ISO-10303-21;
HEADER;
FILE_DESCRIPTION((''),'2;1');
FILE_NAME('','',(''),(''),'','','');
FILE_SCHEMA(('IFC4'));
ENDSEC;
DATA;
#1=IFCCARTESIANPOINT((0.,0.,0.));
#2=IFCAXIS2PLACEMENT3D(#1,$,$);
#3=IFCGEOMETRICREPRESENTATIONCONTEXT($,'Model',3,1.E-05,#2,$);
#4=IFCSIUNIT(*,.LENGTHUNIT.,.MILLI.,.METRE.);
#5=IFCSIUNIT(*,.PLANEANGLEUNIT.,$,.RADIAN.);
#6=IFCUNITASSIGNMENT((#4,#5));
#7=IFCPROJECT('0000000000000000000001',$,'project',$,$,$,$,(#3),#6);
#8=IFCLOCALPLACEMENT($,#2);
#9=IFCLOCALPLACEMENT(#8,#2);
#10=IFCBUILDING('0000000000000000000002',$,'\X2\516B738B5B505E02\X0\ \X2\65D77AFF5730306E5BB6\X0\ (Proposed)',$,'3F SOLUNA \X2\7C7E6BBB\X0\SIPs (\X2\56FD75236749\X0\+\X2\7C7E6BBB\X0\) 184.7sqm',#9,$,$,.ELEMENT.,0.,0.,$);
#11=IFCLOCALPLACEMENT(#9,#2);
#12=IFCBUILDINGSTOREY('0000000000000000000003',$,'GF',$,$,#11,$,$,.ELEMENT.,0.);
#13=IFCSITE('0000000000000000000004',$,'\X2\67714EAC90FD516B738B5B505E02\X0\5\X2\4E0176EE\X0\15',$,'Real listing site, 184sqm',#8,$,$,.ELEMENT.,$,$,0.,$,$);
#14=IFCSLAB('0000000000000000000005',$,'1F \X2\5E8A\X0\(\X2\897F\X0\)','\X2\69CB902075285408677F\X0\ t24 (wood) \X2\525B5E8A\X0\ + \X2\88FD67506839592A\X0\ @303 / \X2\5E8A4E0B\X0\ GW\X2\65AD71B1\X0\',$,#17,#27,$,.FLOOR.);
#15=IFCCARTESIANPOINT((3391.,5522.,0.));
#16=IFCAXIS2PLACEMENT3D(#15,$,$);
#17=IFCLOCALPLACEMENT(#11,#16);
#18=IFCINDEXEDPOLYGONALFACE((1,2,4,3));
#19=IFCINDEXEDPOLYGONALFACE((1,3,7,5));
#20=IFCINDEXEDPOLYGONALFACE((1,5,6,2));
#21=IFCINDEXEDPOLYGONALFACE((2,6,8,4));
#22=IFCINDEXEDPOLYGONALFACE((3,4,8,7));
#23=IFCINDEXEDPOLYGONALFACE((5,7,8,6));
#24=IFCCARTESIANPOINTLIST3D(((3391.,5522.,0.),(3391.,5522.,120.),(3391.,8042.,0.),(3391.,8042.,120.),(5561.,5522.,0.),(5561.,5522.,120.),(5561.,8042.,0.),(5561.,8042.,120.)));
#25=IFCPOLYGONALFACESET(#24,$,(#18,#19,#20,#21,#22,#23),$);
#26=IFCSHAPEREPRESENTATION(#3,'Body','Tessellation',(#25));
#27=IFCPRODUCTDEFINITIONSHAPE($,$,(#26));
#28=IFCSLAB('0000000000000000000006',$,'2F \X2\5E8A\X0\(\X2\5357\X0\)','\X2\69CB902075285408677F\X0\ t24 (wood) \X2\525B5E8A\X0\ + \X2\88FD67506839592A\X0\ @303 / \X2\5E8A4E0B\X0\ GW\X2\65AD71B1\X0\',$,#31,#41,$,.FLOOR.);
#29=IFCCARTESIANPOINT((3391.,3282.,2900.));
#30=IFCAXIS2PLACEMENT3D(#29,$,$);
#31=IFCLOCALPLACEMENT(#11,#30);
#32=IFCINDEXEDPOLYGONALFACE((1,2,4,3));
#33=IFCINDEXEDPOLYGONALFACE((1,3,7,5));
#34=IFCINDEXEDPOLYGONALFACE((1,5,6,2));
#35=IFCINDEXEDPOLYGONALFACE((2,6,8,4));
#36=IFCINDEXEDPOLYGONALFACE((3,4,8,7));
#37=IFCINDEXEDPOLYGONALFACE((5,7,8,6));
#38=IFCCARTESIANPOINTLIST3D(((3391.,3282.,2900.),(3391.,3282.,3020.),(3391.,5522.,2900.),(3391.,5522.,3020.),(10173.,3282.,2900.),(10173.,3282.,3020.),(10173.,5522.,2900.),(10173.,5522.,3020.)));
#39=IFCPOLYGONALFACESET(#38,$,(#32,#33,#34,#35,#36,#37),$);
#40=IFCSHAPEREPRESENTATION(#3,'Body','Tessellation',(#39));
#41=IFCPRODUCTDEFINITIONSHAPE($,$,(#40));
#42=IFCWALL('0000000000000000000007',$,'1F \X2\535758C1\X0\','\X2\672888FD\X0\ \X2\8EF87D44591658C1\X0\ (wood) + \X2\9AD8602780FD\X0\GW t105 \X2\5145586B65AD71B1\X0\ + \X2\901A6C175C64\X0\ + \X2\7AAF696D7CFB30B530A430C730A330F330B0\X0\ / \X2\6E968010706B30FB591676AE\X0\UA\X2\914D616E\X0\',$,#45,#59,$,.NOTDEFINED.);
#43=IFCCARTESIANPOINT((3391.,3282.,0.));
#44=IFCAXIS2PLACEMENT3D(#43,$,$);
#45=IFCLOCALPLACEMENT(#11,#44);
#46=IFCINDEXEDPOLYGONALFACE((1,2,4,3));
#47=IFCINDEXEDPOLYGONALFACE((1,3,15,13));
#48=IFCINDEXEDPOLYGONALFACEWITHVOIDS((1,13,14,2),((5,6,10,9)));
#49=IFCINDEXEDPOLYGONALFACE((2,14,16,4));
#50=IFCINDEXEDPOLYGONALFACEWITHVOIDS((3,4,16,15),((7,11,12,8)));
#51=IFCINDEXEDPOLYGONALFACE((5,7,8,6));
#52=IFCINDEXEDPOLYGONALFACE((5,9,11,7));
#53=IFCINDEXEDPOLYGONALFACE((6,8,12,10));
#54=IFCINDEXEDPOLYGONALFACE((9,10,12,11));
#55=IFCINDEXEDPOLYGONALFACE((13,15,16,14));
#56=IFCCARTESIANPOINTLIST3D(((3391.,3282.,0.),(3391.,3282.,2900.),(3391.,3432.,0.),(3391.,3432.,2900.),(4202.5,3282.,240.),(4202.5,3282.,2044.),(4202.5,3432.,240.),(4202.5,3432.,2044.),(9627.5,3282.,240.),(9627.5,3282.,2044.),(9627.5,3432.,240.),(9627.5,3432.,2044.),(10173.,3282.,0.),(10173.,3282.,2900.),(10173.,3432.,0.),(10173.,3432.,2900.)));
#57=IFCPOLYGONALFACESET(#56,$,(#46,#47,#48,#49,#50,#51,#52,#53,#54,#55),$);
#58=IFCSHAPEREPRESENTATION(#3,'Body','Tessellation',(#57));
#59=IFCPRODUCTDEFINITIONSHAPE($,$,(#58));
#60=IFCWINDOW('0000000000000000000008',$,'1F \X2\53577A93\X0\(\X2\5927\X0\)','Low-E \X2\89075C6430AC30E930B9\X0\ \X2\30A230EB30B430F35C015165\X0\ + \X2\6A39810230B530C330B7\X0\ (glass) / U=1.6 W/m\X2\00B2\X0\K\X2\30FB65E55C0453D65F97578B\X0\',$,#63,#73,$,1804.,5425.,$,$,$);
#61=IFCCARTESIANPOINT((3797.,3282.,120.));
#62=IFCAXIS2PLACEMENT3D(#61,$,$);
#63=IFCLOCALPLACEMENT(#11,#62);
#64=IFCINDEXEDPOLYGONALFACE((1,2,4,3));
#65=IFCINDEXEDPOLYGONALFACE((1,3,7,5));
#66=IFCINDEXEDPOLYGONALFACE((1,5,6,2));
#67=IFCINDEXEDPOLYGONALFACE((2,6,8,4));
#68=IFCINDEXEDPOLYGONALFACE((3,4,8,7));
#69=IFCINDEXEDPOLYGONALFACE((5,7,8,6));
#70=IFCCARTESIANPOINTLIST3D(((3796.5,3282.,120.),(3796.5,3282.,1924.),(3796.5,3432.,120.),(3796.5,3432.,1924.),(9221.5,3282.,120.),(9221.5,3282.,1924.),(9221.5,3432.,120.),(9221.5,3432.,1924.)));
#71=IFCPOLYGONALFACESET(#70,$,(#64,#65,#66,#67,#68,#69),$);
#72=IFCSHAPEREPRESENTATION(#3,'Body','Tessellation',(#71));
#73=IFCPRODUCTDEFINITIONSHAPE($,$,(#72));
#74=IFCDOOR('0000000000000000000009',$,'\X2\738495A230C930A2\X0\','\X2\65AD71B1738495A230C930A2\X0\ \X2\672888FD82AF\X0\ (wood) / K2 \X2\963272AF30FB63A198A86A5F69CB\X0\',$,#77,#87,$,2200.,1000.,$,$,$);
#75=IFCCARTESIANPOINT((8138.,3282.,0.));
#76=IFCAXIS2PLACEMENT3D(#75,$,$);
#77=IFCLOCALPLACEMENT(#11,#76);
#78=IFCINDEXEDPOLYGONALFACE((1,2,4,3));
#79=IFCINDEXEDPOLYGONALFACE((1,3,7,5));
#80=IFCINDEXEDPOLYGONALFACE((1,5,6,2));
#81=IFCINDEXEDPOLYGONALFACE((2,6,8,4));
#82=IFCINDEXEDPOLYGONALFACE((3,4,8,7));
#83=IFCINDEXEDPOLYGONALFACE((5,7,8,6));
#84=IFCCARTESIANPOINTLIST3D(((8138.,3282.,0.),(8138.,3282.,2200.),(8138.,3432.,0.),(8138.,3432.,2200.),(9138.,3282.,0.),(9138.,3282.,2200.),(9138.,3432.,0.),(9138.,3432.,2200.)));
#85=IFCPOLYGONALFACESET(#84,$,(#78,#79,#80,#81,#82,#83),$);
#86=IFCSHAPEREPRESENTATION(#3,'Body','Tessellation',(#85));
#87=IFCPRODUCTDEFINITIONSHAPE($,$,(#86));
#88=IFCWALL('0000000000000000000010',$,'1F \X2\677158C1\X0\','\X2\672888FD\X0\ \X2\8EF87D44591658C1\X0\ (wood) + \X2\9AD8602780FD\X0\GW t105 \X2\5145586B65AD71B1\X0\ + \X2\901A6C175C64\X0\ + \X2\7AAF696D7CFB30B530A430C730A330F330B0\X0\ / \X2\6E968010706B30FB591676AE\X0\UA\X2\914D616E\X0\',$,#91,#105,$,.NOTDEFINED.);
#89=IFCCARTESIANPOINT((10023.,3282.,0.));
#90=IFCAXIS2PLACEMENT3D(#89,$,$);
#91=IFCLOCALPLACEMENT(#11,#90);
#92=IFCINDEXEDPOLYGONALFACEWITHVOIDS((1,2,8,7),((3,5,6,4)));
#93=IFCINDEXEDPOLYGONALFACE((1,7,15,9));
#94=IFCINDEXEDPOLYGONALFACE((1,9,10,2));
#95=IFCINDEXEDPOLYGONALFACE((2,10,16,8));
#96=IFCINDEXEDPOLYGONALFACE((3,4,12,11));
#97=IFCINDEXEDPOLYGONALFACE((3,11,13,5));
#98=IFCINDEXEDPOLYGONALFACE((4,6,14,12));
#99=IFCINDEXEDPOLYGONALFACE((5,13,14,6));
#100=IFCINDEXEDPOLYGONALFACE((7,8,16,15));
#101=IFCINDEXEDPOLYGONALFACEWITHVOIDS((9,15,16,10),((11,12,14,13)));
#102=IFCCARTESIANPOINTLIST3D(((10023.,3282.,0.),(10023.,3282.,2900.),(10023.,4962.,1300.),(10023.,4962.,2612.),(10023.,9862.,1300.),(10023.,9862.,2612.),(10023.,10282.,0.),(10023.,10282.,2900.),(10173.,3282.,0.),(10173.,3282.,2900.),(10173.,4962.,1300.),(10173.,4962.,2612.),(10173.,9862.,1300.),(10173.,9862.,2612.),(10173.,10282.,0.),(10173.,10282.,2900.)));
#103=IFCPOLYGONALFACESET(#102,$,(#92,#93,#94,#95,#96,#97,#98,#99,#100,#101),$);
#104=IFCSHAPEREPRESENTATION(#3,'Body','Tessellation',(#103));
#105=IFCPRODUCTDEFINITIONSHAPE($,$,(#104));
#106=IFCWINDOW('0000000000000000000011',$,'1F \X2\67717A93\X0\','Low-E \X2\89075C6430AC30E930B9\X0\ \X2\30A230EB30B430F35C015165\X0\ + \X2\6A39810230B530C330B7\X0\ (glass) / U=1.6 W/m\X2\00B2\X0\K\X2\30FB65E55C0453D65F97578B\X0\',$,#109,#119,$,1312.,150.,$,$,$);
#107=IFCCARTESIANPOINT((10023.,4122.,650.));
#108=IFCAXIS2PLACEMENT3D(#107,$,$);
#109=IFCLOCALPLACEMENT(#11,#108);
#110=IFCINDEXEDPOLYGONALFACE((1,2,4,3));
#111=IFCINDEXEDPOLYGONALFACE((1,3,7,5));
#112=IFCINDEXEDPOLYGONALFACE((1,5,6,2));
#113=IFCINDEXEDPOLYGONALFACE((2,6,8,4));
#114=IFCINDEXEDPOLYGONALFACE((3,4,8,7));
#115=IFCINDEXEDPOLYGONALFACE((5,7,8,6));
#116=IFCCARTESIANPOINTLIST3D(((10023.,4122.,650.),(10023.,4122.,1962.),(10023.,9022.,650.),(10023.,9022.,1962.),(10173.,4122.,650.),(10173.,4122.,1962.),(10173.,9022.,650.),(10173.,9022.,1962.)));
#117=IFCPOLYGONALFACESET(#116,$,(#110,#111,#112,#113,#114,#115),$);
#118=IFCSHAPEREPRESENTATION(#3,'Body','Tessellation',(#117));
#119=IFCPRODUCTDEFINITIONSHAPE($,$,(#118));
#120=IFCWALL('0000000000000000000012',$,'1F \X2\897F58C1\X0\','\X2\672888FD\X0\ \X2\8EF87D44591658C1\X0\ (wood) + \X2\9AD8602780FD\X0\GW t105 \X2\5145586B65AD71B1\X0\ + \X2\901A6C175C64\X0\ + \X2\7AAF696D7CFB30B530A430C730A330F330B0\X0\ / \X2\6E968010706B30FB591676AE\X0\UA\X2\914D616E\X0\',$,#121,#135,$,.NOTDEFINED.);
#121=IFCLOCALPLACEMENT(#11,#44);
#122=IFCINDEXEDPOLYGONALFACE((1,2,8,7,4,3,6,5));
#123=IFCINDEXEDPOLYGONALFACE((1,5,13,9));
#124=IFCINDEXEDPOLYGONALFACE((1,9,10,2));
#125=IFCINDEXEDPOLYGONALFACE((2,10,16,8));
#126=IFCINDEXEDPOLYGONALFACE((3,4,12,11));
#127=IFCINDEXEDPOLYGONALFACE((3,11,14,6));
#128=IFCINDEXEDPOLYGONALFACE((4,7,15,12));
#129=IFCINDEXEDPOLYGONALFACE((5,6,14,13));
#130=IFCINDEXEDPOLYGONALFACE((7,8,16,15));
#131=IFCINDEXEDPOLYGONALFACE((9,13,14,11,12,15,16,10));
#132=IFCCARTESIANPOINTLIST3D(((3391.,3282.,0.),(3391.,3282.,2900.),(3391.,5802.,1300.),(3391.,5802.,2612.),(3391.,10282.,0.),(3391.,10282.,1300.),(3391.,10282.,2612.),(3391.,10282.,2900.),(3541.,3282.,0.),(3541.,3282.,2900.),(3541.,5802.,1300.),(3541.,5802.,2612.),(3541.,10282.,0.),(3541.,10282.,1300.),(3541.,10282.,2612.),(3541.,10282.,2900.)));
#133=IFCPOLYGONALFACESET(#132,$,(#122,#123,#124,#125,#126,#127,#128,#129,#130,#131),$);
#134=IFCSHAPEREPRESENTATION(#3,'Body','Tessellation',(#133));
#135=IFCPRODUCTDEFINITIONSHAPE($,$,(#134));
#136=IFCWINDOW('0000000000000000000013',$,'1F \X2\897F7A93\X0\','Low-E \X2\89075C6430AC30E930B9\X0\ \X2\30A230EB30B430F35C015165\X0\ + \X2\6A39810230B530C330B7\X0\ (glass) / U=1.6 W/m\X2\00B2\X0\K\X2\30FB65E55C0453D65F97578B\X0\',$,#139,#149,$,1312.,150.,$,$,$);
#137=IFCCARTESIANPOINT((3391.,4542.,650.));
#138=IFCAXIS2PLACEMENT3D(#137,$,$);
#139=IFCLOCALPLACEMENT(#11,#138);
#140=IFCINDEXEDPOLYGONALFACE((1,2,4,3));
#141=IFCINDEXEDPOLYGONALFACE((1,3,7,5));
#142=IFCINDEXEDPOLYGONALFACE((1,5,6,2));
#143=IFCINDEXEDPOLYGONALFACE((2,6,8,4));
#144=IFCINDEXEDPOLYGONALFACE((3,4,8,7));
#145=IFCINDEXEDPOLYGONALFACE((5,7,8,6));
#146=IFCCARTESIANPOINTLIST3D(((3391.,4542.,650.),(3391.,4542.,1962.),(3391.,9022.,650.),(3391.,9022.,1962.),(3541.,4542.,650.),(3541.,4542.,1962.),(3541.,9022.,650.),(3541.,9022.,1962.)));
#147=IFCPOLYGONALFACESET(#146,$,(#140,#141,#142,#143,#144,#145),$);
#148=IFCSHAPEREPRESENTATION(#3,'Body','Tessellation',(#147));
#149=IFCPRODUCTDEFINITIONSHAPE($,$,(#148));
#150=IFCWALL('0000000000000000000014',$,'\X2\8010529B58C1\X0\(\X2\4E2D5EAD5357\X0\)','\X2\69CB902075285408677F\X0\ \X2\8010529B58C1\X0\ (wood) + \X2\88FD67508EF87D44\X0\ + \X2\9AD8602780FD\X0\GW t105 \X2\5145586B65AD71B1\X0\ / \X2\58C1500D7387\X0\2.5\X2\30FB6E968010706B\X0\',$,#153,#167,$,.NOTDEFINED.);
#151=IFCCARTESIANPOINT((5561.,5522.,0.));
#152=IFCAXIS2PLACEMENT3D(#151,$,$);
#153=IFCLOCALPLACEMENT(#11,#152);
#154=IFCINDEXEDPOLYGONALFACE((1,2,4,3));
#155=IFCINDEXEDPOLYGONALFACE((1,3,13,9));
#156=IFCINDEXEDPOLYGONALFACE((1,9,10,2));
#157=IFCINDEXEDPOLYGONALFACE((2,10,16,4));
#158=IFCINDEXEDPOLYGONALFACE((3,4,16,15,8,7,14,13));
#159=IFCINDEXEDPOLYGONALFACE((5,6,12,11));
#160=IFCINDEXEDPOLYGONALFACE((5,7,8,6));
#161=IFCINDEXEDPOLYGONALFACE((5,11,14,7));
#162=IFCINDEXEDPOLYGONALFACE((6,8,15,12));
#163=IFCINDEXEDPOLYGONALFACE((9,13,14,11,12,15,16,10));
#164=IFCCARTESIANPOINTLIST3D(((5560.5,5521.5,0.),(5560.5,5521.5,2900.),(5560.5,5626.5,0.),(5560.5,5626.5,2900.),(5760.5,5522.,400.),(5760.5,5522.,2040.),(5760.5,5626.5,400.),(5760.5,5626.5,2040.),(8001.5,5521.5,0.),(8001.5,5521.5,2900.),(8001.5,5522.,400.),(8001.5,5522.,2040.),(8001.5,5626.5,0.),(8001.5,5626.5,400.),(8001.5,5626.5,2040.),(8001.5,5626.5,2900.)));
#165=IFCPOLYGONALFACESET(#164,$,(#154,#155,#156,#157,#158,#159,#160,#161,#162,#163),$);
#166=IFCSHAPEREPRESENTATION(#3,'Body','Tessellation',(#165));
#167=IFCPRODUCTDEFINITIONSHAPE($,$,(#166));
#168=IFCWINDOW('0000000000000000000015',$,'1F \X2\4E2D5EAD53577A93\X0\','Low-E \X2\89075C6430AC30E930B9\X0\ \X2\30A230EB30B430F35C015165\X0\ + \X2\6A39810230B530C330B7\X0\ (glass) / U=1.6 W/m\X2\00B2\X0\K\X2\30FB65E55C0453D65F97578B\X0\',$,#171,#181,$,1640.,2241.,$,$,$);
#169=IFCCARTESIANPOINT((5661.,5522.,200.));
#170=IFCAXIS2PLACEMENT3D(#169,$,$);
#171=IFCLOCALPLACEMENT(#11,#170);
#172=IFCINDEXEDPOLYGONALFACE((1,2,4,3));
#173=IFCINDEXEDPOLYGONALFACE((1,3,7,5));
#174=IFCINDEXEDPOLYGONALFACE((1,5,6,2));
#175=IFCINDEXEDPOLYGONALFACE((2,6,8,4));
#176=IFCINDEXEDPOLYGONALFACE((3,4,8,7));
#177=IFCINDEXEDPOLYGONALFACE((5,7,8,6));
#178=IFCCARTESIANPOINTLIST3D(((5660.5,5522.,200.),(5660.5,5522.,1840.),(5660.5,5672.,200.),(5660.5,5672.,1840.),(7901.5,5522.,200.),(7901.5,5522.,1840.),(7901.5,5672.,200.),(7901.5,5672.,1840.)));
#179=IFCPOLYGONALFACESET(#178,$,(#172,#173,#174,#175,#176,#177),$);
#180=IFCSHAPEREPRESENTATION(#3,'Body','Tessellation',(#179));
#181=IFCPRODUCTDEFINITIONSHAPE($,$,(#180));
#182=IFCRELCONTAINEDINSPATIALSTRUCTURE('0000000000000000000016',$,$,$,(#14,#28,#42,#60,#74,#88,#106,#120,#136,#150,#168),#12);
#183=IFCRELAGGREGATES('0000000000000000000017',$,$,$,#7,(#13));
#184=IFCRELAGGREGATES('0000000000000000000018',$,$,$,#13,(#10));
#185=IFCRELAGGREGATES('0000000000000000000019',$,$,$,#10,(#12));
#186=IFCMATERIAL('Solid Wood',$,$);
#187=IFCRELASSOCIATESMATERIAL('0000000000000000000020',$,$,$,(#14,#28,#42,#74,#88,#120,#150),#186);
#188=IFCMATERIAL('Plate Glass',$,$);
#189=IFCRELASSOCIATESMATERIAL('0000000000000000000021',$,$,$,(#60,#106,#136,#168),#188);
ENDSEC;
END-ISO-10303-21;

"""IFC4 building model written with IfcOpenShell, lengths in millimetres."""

from ifc_helpers import new_model, si_unit, frame, frame_2d, origin, place, context, project, spatial, rectangle, extrude, material, element, fill, save


model = new_model("IFC4")

# Units and contexts
model_context = context("Model", 3, precision=1e-05, world=origin())
ifc_project = project(units=[si_unit("LENGTHUNIT", "METRE", prefix="MILLI"), si_unit("PLANEANGLEUNIT", "RADIAN")], contexts=[model_context])

# Site, building, storey
site_placement = place(None, origin())
site = spatial("IfcSite", under=ifc_project, at=site_placement, Name="東京都八王子市5丁目15", ObjectType="Real listing site, 184sqm", CompositionType="ELEMENT", RefElevation=0.0)
building_placement = place(site_placement, origin())
building = spatial("IfcBuilding", under=site, at=building_placement, Name="八王子市 旗竿地の家 (Proposed)", ObjectType="3F SOLUNA 籾殻SIPs (国産杉+籾殻) 184.7sqm", CompositionType="ELEMENT", ElevationOfRefHeight=0.0, ElevationOfTerrain=0.0)
storey_placement = place(building_placement, origin())
storey = spatial("IfcBuildingStorey", under=building, at=storey_placement, Name="GF", CompositionType="ELEMENT", Elevation=0.0)

# Slabs
ifc_material_1 = material(Name="Solid Wood")
slab_1_placement = place(storey_placement, frame((3391.0, 5522.0, 0.0)))
element("IfcSlab", 1, at=slab_1_placement, inside=storey, material=ifc_material_1, Name="1F 床(西)", Description="構造用合板 t24 (wood) 剛床 + 製材根太 @303 / 床下 GW断熱", PredefinedType="FLOOR", context=model_context, shape_type="SweptSolid", body=[
    extrude(rectangle(XDim=2170.0, YDim=2520.0, at=frame_2d((1085.0, 1260.0))), frame((3391.0, 5522.0, 0.0)), (0.0, 0.0, 1.0), 120.0),
])
slab_2_placement = place(storey_placement, frame((3391.0, 3282.0, 2900.0)))
element("IfcSlab", 2, at=slab_2_placement, inside=storey, material=ifc_material_1, Name="2F 床(南)", Description="構造用合板 t24 (wood) 剛床 + 製材根太 @303 / 床下 GW断熱", PredefinedType="FLOOR", context=model_context, shape_type="SweptSolid", body=[
    extrude(rectangle(XDim=6782.0, YDim=2240.0, at=frame_2d((3391.0, 1120.0))), frame((3391.0, 3282.0, 2900.0)), (0.0, 0.0, 1.0), 120.0),
])

# Wall, openings, window, door
wall_1_placement = place(storey_placement, frame((3391.0, 3282.0, 0.0)))
wall_1 = element("IfcWall", 3, at=wall_1_placement, inside=storey, material=ifc_material_1, Name="1F 南壁", Description="木製 軸組外壁 (wood) + 高性能GW t105 充填断熱 + 通気層 + 窯業系サイディング / 準耐火・外皮UA配慮", PredefinedType="NOTDEFINED", context=model_context, shape_type="SweptSolid", body=[
    extrude(rectangle(XDim=6782.0, YDim=150.0, at=frame_2d((3391.0, 75.0))), frame((3391.0, 3282.0, 0.0)), (0.0, 0.0, 1.0), 2900.0),
])
opening_1_placement = place(storey_placement, frame((3797.0, 3282.0, 120.0)))
opening_1 = element("IfcOpeningElement", 4, at=opening_1_placement, cuts=wall_1, PredefinedType="NOTDEFINED", context=model_context, shape_type="SweptSolid", body=[
    extrude(rectangle(XDim=5425.0, YDim=150.0, at=frame_2d((2712.0, 75.0))), frame((3797.0, 3282.0, 120.0)), (0.0, 0.0, 1.0), 1804.0),
])
opening_2_placement = place(storey_placement, frame((8138.0, 3282.0, 0.0)))
opening_2 = element("IfcOpeningElement", 5, at=opening_2_placement, cuts=wall_1, PredefinedType="NOTDEFINED", context=model_context, shape_type="SweptSolid", body=[
    extrude(rectangle(XDim=1000.0, YDim=150.0, at=frame_2d((500.0, 75.0))), frame((8138.0, 3282.0, 0.0)), (0.0, 0.0, 1.0), 2200.0),
])
ifc_material_2 = material(Name="Plate Glass")
window_1_placement = place(storey_placement, frame((3797.0, 3282.0, 120.0)))
window_1 = element("IfcWindow", 6, at=window_1_placement, inside=storey, material=ifc_material_2, Name="1F 南窓(大)", Description="Low-E 複層ガラス アルゴン封入 + 樹脂サッシ (glass) / U=1.6 W/m²K・日射取得型", OverallHeight=1804.0, OverallWidth=5425.0, context=model_context, shape_type="SweptSolid", body=[
    extrude(rectangle(XDim=5425.0, YDim=150.0, at=frame_2d((2712.0, 75.0))), frame((3797.0, 3282.0, 120.0)), (0.0, 0.0, 1.0), 1804.0),
])
fill(opening_1, window_1)
door_placement = place(storey_placement, frame((8138.0, 3282.0, 0.0)))
door = element("IfcDoor", 7, at=door_placement, inside=storey, material=ifc_material_1, Name="玄関ドア", Description="断熱玄関ドア 木製芯 (wood) / K2 防犯・採風機構", OverallHeight=2200.0, OverallWidth=1000.0, context=model_context, shape_type="SweptSolid", body=[
    extrude(rectangle(XDim=1000.0, YDim=150.0, at=frame_2d((500.0, 75.0))), frame((8138.0, 3282.0, 0.0)), (0.0, 0.0, 1.0), 2200.0),
])
fill(opening_2, door)

# Walls, openings, windows
wall_2_placement = place(storey_placement, frame((10023.0, 3282.0, 0.0)))
wall_2 = element("IfcWall", 8, at=wall_2_placement, inside=storey, material=ifc_material_1, Name="1F 東壁", Description="木製 軸組外壁 (wood) + 高性能GW t105 充填断熱 + 通気層 + 窯業系サイディング / 準耐火・外皮UA配慮", PredefinedType="NOTDEFINED", context=model_context, shape_type="SweptSolid", body=[
    extrude(rectangle(XDim=150.0, YDim=7000.0, at=frame_2d((75.0, 3500.0))), frame((10023.0, 3282.0, 0.0)), (0.0, 0.0, 1.0), 2900.0),
])
opening_3_placement = place(storey_placement, frame((10023.0, 4122.0, 650.0)))
opening_3 = element("IfcOpeningElement", 9, at=opening_3_placement, cuts=wall_2, PredefinedType="NOTDEFINED", context=model_context, shape_type="SweptSolid", body=[
    extrude(rectangle(XDim=150.0, YDim=4900.0, at=frame_2d((75.0, 2450.0))), frame((10023.0, 4122.0, 650.0)), (0.0, 0.0, 1.0), 1312.0),
])
window_2_placement = place(storey_placement, frame((10023.0, 4122.0, 650.0)))
window_2 = element("IfcWindow", 10, at=window_2_placement, inside=storey, material=ifc_material_2, Name="1F 東窓", Description="Low-E 複層ガラス アルゴン封入 + 樹脂サッシ (glass) / U=1.6 W/m²K・日射取得型", OverallHeight=1312.0, OverallWidth=150.0, context=model_context, shape_type="SweptSolid", body=[
    extrude(rectangle(XDim=150.0, YDim=4900.0, at=frame_2d((75.0, 2450.0))), frame((10023.0, 4122.0, 650.0)), (0.0, 0.0, 1.0), 1312.0),
])
fill(opening_3, window_2)
wall_3_placement = place(storey_placement, frame((3391.0, 3282.0, 0.0)))
wall_3 = element("IfcWall", 11, at=wall_3_placement, inside=storey, material=ifc_material_1, Name="1F 西壁", Description="木製 軸組外壁 (wood) + 高性能GW t105 充填断熱 + 通気層 + 窯業系サイディング / 準耐火・外皮UA配慮", PredefinedType="NOTDEFINED", context=model_context, shape_type="SweptSolid", body=[
    extrude(rectangle(XDim=150.0, YDim=7000.0, at=frame_2d((75.0, 3500.0))), frame((3391.0, 3282.0, 0.0)), (0.0, 0.0, 1.0), 2900.0),
])
opening_4_placement = place(storey_placement, frame((3391.0, 4542.0, 650.0)))
opening_4 = element("IfcOpeningElement", 12, at=opening_4_placement, cuts=wall_3, PredefinedType="NOTDEFINED", context=model_context, shape_type="SweptSolid", body=[
    extrude(rectangle(XDim=150.0, YDim=4480.0, at=frame_2d((75.0, 2240.0))), frame((3391.0, 4542.0, 650.0)), (0.0, 0.0, 1.0), 1312.0),
])
window_3_placement = place(storey_placement, frame((3391.0, 4542.0, 650.0)))
window_3 = element("IfcWindow", 13, at=window_3_placement, inside=storey, material=ifc_material_2, Name="1F 西窓", Description="Low-E 複層ガラス アルゴン封入 + 樹脂サッシ (glass) / U=1.6 W/m²K・日射取得型", OverallHeight=1312.0, OverallWidth=150.0, context=model_context, shape_type="SweptSolid", body=[
    extrude(rectangle(XDim=150.0, YDim=4480.0, at=frame_2d((75.0, 2240.0))), frame((3391.0, 4542.0, 650.0)), (0.0, 0.0, 1.0), 1312.0),
])
fill(opening_4, window_3)
wall_4_placement = place(storey_placement, frame((5561.0, 5522.0, 0.0)))
wall_4 = element("IfcWall", 14, at=wall_4_placement, inside=storey, material=ifc_material_1, Name="耐力壁(中庭南)", Description="構造用合板 耐力壁 (wood) + 製材軸組 + 高性能GW t105 充填断熱 / 壁倍率2.5・準耐火", PredefinedType="NOTDEFINED", context=model_context, shape_type="SweptSolid", body=[
    extrude(rectangle(XDim=2441.0, YDim=105.0, at=frame_2d((1220.0, 52.0))), frame((5561.0, 5522.0, 0.0)), (0.0, 0.0, 1.0), 2900.0),
])
opening_5_placement = place(storey_placement, frame((5661.0, 5522.0, 200.0)))
opening_5 = element("IfcOpeningElement", 15, at=opening_5_placement, cuts=wall_4, PredefinedType="NOTDEFINED", context=model_context, shape_type="SweptSolid", body=[
    extrude(rectangle(XDim=2241.0, YDim=150.0, at=frame_2d((1120.0, 75.0))), frame((5661.0, 5522.0, 200.0)), (0.0, 0.0, 1.0), 1640.0),
])
window_4_placement = place(storey_placement, frame((5661.0, 5522.0, 200.0)))
window_4 = element("IfcWindow", 16, at=window_4_placement, inside=storey, material=ifc_material_2, Name="1F 中庭南窓", Description="Low-E 複層ガラス アルゴン封入 + 樹脂サッシ (glass) / U=1.6 W/m²K・日射取得型", OverallHeight=1640.0, OverallWidth=2241.0, context=model_context, shape_type="SweptSolid", body=[
    extrude(rectangle(XDim=2241.0, YDim=150.0, at=frame_2d((1120.0, 75.0))), frame((5661.0, 5522.0, 200.0)), (0.0, 0.0, 1.0), 1640.0),
])
fill(opening_5, window_4)

save(model, "model.ifc")
